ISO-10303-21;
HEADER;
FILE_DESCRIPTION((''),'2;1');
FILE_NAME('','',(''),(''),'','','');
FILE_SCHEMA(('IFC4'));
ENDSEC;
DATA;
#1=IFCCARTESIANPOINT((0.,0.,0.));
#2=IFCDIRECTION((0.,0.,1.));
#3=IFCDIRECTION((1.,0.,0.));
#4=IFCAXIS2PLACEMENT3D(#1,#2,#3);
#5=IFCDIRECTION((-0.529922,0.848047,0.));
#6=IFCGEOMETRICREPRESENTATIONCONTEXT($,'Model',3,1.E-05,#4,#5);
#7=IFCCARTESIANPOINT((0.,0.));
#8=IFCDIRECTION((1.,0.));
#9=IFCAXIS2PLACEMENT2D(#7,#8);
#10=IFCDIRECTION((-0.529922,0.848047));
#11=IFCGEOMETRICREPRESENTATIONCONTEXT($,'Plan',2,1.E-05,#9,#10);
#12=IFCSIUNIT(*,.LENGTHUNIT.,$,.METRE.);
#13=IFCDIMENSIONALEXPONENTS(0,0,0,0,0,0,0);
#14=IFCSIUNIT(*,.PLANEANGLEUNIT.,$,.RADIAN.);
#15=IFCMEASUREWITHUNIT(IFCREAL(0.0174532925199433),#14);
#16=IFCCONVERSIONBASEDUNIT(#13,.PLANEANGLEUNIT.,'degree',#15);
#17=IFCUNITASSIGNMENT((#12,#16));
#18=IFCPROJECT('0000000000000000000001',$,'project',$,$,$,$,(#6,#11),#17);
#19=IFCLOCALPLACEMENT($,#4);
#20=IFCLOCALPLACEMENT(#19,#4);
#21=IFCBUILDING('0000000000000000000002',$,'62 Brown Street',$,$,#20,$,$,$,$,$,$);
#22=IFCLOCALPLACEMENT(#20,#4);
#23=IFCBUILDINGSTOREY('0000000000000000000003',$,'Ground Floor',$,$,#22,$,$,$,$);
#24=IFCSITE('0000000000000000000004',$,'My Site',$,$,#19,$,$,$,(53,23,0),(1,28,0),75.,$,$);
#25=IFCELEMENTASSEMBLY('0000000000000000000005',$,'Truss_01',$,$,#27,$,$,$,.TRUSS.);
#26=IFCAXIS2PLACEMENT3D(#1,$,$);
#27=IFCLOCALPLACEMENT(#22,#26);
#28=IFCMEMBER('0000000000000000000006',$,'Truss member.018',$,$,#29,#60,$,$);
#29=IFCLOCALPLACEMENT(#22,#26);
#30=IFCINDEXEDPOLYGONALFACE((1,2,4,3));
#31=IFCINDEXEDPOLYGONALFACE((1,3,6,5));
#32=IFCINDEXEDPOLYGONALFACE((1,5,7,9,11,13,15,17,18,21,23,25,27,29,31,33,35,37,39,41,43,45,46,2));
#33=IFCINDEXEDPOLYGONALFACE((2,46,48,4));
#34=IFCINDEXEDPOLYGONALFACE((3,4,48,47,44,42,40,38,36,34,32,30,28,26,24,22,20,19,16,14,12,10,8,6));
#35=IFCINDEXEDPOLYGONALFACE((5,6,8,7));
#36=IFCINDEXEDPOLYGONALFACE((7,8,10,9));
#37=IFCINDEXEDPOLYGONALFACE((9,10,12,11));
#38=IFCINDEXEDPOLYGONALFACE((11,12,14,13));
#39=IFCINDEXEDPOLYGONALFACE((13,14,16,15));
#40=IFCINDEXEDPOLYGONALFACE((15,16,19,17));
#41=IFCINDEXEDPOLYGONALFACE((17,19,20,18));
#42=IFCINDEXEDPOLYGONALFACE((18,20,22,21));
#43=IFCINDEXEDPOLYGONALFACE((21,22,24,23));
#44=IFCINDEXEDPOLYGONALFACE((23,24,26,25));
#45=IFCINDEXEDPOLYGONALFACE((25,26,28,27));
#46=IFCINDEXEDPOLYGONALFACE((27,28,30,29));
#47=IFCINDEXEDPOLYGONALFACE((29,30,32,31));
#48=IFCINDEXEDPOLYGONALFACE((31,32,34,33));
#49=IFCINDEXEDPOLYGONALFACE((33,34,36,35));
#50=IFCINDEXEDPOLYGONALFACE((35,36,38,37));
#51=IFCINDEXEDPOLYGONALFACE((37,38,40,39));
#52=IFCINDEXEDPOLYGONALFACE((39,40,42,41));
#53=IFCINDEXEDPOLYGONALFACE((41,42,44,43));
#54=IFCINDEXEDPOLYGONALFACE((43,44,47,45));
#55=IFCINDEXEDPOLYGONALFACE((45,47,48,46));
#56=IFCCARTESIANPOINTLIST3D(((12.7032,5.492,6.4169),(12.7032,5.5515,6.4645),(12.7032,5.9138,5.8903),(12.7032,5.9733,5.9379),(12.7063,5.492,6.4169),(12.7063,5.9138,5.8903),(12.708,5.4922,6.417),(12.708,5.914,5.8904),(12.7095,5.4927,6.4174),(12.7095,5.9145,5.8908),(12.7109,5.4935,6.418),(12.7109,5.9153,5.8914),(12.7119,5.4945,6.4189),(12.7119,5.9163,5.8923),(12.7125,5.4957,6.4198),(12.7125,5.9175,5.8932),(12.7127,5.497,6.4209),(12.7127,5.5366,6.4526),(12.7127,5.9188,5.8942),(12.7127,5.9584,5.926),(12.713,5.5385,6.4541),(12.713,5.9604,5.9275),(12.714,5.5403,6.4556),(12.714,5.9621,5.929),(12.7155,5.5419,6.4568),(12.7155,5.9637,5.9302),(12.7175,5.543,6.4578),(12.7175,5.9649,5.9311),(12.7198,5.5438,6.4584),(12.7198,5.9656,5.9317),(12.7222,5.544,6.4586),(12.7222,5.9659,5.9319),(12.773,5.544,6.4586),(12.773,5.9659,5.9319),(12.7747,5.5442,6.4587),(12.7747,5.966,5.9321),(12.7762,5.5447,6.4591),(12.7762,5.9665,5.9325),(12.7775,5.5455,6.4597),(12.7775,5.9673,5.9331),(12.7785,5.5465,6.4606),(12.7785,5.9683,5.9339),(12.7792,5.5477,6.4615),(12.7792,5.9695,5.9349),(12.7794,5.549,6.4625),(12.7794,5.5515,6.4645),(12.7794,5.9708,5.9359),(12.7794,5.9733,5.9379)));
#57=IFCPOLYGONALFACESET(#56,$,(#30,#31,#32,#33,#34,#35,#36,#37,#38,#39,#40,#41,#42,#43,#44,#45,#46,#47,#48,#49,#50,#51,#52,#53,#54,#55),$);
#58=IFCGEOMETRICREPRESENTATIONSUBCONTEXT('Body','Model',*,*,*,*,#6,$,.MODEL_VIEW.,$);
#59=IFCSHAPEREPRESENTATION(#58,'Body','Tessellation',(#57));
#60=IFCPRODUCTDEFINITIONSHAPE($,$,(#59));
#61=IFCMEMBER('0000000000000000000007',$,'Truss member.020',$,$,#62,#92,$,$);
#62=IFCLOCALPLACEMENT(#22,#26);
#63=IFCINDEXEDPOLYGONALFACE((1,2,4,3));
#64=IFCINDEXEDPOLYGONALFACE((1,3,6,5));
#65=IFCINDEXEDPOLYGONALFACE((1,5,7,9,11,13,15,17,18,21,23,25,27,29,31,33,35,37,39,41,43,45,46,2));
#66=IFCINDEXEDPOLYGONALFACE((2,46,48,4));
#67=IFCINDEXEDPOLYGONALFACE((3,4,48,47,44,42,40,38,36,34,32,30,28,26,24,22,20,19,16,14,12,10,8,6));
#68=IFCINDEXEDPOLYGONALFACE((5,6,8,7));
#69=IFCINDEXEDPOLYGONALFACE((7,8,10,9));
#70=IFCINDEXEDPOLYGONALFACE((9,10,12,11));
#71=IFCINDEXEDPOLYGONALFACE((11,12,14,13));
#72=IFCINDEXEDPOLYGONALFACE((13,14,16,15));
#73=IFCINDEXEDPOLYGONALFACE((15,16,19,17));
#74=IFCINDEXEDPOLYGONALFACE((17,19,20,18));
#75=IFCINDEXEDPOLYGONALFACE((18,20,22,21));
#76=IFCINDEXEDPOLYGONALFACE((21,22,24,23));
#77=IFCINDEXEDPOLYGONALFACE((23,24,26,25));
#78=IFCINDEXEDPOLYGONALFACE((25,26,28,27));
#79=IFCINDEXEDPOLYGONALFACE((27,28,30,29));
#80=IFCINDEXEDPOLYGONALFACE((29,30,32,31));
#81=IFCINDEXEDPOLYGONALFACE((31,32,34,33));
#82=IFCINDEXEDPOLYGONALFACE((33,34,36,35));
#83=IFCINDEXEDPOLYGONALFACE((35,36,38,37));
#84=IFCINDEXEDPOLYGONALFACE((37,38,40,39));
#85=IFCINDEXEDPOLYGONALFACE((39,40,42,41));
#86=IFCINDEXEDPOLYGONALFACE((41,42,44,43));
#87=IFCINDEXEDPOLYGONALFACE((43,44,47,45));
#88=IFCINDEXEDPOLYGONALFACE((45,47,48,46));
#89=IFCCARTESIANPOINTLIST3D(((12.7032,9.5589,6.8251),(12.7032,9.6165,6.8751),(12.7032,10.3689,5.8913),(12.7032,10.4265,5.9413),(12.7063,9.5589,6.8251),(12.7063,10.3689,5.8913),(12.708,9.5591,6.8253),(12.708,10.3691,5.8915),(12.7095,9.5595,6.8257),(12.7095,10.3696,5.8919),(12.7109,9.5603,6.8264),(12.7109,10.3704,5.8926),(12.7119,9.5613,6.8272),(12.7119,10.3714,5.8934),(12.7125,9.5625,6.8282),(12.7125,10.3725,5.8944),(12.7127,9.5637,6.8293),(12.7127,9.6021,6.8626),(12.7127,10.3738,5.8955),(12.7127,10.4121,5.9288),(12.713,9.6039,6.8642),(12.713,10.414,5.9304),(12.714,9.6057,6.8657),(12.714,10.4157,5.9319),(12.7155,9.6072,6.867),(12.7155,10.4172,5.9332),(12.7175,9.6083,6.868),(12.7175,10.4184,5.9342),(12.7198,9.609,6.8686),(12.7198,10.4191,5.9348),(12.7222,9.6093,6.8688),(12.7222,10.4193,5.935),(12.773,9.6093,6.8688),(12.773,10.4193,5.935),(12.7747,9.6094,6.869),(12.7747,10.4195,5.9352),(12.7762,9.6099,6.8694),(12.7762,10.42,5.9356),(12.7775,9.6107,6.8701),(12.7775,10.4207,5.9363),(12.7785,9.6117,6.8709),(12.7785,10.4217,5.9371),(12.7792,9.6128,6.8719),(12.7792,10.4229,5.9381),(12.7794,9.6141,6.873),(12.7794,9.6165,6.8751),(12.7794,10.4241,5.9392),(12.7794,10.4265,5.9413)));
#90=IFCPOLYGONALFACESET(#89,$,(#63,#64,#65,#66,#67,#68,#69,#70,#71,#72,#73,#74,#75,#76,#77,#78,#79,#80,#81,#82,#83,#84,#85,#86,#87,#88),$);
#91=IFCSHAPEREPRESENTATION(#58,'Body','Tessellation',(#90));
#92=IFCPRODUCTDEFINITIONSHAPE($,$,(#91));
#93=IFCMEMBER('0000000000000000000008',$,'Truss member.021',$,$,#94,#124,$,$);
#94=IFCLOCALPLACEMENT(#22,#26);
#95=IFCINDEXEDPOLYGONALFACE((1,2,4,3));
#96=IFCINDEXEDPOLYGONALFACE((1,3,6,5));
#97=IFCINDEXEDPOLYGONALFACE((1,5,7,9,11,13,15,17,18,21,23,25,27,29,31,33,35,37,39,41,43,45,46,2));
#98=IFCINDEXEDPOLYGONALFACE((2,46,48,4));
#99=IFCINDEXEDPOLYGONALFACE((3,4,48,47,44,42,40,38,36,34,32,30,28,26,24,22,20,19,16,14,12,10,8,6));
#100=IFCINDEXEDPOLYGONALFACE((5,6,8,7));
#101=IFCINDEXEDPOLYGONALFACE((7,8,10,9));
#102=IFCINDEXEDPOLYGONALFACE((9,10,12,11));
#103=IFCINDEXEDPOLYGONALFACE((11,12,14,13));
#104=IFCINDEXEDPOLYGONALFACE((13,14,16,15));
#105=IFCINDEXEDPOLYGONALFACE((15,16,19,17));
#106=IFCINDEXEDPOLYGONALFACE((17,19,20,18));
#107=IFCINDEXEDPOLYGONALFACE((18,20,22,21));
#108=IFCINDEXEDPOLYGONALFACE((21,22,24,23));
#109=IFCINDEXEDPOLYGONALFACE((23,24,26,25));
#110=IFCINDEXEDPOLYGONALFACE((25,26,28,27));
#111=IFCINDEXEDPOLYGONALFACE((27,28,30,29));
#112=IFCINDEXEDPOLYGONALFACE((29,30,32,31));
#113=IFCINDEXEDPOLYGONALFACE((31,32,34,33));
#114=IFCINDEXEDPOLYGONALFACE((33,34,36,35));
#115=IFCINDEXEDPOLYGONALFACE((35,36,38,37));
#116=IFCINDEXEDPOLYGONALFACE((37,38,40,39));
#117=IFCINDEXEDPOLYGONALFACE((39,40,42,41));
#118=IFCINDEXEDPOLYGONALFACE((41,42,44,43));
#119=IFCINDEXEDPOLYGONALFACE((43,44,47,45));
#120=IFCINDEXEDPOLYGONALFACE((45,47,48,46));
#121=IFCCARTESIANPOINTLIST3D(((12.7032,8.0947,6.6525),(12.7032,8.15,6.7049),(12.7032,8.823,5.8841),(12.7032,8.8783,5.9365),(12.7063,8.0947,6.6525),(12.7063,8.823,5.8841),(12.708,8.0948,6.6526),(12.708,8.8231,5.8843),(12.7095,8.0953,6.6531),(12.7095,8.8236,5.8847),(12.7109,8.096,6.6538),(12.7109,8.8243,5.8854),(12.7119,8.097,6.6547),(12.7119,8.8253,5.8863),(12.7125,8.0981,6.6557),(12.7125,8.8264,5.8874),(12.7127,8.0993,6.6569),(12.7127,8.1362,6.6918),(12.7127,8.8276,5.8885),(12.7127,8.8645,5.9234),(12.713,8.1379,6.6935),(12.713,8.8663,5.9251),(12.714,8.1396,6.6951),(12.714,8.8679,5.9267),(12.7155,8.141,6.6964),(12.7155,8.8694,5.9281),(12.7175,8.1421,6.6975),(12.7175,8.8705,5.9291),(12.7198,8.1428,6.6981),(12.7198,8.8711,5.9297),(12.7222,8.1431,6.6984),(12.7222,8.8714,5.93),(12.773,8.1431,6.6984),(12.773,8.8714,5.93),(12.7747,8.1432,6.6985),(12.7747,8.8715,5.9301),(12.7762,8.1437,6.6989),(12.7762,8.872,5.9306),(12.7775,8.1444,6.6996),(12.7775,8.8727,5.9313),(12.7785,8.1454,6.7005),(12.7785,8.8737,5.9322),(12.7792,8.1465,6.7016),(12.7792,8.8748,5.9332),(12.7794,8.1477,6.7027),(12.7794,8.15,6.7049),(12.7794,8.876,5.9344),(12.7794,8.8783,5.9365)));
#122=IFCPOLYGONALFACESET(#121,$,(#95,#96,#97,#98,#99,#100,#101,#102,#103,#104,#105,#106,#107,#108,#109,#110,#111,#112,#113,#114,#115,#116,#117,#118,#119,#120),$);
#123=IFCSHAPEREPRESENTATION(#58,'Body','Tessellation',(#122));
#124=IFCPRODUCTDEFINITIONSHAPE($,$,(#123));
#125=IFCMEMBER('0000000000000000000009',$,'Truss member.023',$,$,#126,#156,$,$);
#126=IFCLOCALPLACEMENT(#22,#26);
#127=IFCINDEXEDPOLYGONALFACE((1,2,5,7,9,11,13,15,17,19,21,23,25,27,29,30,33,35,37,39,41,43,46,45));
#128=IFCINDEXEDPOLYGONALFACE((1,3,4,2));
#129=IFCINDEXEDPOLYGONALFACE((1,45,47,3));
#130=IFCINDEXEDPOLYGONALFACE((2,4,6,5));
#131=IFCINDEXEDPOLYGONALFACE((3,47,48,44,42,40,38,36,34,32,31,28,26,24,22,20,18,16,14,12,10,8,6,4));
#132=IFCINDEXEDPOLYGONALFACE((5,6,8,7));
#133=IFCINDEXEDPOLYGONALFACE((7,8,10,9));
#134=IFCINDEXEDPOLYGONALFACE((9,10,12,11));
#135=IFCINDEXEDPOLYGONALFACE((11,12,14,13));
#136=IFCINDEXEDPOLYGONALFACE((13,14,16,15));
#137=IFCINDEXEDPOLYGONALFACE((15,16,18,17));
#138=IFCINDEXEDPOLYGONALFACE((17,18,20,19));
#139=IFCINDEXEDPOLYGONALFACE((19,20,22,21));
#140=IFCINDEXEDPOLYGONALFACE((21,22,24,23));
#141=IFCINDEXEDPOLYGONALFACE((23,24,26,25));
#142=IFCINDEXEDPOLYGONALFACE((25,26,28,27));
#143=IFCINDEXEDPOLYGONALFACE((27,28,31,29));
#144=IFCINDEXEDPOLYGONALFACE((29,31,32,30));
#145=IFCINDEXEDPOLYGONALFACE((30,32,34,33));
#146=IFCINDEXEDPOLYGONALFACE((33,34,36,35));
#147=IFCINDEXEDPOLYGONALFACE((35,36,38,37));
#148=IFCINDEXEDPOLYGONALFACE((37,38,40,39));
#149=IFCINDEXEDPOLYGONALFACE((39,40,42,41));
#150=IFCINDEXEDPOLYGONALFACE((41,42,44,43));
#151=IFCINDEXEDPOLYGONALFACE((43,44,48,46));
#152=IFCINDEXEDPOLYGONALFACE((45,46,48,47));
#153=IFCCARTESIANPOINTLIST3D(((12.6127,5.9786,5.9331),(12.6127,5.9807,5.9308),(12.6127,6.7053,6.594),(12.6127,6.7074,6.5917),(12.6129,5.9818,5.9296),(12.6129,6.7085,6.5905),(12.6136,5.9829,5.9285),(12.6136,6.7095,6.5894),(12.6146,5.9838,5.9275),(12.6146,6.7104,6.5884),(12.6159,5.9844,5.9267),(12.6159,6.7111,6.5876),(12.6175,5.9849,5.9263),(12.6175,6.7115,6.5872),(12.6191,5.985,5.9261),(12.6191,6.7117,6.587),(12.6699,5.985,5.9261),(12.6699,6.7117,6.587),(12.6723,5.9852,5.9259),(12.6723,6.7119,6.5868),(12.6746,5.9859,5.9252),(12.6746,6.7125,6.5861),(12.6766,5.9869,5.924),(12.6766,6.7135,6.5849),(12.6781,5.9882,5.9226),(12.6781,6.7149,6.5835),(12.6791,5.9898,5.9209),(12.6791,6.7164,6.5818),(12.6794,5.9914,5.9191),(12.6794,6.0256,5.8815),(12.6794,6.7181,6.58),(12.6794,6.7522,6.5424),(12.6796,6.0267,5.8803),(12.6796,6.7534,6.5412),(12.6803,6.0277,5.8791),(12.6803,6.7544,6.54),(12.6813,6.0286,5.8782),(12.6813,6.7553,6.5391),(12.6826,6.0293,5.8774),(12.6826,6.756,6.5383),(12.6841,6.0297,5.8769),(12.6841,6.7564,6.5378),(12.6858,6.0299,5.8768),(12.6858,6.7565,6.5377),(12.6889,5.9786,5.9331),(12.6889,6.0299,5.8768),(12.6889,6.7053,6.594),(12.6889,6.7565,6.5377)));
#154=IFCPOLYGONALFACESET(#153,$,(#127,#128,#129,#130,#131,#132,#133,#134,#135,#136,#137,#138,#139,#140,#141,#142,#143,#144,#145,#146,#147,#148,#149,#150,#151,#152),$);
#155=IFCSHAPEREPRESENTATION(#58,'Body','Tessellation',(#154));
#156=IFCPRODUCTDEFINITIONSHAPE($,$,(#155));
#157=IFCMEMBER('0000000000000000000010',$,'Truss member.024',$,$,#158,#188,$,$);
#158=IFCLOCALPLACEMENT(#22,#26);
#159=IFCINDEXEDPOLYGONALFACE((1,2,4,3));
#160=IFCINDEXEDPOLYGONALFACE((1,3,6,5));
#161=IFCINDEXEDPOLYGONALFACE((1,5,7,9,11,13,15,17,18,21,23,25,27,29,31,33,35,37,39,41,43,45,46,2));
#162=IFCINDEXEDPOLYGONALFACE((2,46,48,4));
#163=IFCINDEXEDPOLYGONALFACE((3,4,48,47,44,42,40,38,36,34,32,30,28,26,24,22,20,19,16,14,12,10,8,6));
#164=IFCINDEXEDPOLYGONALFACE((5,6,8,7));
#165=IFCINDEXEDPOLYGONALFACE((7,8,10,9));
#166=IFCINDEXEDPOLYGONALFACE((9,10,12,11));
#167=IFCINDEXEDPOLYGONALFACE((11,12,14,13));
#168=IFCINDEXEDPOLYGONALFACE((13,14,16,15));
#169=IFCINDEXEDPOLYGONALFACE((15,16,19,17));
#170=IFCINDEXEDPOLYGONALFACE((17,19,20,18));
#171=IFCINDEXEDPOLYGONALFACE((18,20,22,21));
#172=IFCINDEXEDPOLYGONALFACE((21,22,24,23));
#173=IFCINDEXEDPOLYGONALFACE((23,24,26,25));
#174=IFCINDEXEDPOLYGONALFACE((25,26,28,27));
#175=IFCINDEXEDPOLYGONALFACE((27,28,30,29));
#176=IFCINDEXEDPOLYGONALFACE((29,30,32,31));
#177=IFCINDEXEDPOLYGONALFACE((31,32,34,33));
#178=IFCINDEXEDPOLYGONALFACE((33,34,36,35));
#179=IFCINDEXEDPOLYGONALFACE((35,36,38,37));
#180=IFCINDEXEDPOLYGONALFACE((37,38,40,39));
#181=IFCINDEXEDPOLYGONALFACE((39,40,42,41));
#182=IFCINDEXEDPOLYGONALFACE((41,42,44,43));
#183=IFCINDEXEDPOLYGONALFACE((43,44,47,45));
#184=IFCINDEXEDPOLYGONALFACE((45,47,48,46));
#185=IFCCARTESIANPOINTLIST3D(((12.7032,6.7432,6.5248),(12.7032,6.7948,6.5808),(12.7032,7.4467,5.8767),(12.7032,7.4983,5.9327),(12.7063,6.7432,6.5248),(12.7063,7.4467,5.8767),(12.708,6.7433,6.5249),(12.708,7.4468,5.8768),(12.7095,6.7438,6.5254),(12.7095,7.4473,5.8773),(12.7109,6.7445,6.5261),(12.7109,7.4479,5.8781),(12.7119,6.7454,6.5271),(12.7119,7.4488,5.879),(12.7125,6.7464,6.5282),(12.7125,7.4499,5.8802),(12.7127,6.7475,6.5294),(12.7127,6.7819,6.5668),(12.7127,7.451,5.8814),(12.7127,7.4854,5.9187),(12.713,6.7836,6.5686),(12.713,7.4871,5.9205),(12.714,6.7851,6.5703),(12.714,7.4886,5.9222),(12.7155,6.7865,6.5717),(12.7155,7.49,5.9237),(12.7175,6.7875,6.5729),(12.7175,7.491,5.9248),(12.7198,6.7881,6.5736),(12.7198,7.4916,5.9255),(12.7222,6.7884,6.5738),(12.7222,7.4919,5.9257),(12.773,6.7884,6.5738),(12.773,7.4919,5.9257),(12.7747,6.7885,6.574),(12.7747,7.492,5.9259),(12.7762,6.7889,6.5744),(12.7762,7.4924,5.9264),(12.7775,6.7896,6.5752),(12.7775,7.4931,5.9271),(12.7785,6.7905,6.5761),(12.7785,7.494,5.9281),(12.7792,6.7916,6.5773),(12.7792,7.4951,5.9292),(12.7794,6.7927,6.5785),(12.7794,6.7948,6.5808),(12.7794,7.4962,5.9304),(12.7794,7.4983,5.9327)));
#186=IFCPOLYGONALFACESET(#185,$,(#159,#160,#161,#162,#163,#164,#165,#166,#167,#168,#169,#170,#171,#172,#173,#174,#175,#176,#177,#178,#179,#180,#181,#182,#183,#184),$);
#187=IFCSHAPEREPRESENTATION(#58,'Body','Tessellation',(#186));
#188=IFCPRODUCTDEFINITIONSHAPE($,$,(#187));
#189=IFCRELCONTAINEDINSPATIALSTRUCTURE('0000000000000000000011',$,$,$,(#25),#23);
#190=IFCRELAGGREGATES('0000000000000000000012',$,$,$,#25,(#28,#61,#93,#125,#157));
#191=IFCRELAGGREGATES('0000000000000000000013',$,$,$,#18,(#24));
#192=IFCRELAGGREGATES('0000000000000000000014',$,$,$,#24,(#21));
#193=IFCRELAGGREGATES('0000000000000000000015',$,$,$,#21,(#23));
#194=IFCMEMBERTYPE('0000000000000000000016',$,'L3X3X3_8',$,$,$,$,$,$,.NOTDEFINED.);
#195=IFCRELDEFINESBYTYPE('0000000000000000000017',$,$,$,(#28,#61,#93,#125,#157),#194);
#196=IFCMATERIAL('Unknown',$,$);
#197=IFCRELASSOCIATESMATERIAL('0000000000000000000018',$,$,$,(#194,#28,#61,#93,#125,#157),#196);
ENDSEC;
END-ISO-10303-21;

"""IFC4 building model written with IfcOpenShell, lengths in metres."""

from ifc_helpers import new_model, entity, si_unit, converted_unit, direction, frame, origin_with_axes, origin_2d_with_axis, place, context, subcontext, project, spatial, l_section, extrude, material, material_profile, profile_set, profile_usage, type_object, element, aggregate, save


model = new_model("IFC4")

# Units and contexts
model_context = context("Model", 3, precision=1e-05, world=origin_with_axes(), true_north=direction((-0.529922, 0.848047, 0.0)))
plan_context = context("Plan", 2, precision=1e-05, world=origin_2d_with_axis(), true_north=direction((-0.529922, 0.848047)))
body_context_1 = subcontext(model_context, "Body", "Model", "MODEL_VIEW")
ifc_project = project(units=[si_unit("LENGTHUNIT", "METRE"), converted_unit("PLANEANGLEUNIT", "degree", entity("IfcReal", 0.0174532925199433), si_unit("PLANEANGLEUNIT", "RADIAN"), dimensions=[0, 0, 0, 0, 0, 0, 0])], contexts=[model_context, plan_context])

# Site, building, storey
site_placement = place(None, origin_with_axes())
site = spatial("IfcSite", under=ifc_project, at=site_placement, Name="My Site", RefLatitude=(53, 23, 0), RefLongitude=(1, 28, 0), RefElevation=75.0)
building_placement = place(site_placement, origin_with_axes())
building = spatial("IfcBuilding", under=site, at=building_placement, Name="62 Brown Street")
storey_placement = place(building_placement, origin_with_axes())
storey = spatial("IfcBuildingStorey", under=building, at=storey_placement, Name="Ground Floor")

# Element assembly, members
ifc_material_1 = material(Name="Unknown")
ifc_material_profile_1 = material_profile(ifc_material_1, l_section(Depth=0.0762, Width=0.0762, Thickness=0.0095, FilletRadius=0.0095, EdgeRadius=0.0064))
ifc_profile_set_1 = profile_set([ifc_material_profile_1])
member_type_1 = type_object("IfcMemberType", Name="L3X3X3_8", PredefinedType="NOTDEFINED", material=ifc_profile_set_1)
assembly_1_placement = place(storey_placement, frame((12.7032, 10.4288, 6.9738), z_axis=(0.0, 0.0, 1.0), x_axis=(1.0, 0.0, 0.0)))
assembly_1 = element("IfcElementAssembly", 1, at=assembly_1_placement, inside=storey, Name="Truss_01", PredefinedType="TRUSS")
ifc_profile_usage_1 = profile_usage(ifc_profile_set_1, cardinal=5)
member_1_placement = place(assembly_1_placement, frame((0.0381, -4.907, -0.5331), z_axis=(-0.000001, 0.625169, -0.780489), x_axis=(1.0, 0.000001, 0.0)))
member_1 = element("IfcMember", 2, at=member_1_placement, type_object=member_type_1, material=ifc_profile_usage_1, Name="Truss member.018", context=body_context_1, shape_type="SweptSolid", body=[
    extrude(l_section(Depth=0.0762, Width=0.0762, Thickness=0.0095, FilletRadius=0.0095, EdgeRadius=0.0064), origin_with_axes(), (0.0, 0.0, 1.0), 0.6747),
])
ifc_profile_usage_2 = profile_usage(ifc_profile_set_1, cardinal=5)
member_2_placement = place(assembly_1_placement, frame((0.0381, -0.8411, -0.1236), z_axis=(-0.000001, 0.655276, -0.755389), x_axis=(1.0, 0.000001, 0.0)))
member_2 = element("IfcMember", 3, at=member_2_placement, type_object=member_type_1, material=ifc_profile_usage_2, Name="Truss member.020", context=body_context_1, shape_type="SweptSolid", body=[
    extrude(l_section(Depth=0.0762, Width=0.0762, Thickness=0.0095, FilletRadius=0.0095, EdgeRadius=0.0064), origin_with_axes(), (0.0, 0.0, 1.0), 1.2362),
])
ifc_profile_usage_3 = profile_usage(ifc_profile_set_1, cardinal=5)
member_3_placement = place(assembly_1_placement, frame((0.0381, -2.3065, -0.2951), z_axis=(-0.000001, 0.687927, -0.72578), x_axis=(1.0, 0.0, 0.0)))
member_3 = element("IfcMember", 4, at=member_3_placement, type_object=member_type_1, material=ifc_profile_usage_3, Name="Truss member.021", context=body_context_1, shape_type="SweptSolid", body=[
    extrude(l_section(Depth=0.0762, Width=0.0762, Thickness=0.0095, FilletRadius=0.0095, EdgeRadius=0.0064), origin_with_axes(), (0.0, 0.0, 1.0), 1.0587),
])
ifc_profile_usage_4 = profile_usage(ifc_profile_set_1, cardinal=5)
member_4_placement = place(assembly_1_placement, frame((-0.0524, -3.6979, -0.4079), z_axis=(0.000001, -0.739785, -0.672843), x_axis=(-1.0, -0.000001, 0.0)))
member_4 = element("IfcMember", 5, at=member_4_placement, type_object=member_type_1, material=ifc_profile_usage_4, Name="Truss member.023", context=body_context_1, shape_type="SweptSolid", body=[
    extrude(l_section(Depth=0.0762, Width=0.0762, Thickness=0.0095, FilletRadius=0.0095, EdgeRadius=0.0064), origin_with_axes(), (0.0, 0.0, 1.0), 0.9823),
])
ifc_profile_usage_5 = profile_usage(ifc_profile_set_1, cardinal=5)
member_5_placement = place(assembly_1_placement, frame((0.0381, -3.6598, -0.421), z_axis=(-0.000001, 0.735484, -0.677542), x_axis=(1.0, 0.000001, 0.0)))
member_5 = element("IfcMember", 6, at=member_5_placement, type_object=member_type_1, material=ifc_profile_usage_5, Name="Truss member.024", context=body_context_1, shape_type="SweptSolid", body=[
    extrude(l_section(Depth=0.0762, Width=0.0762, Thickness=0.0095, FilletRadius=0.0095, EdgeRadius=0.0064), origin_with_axes(), (0.0, 0.0, 1.0), 0.9565),
])

aggregate(assembly_1, [member_1, member_2, member_3, member_4, member_5])

save(model, "model.ifc")
